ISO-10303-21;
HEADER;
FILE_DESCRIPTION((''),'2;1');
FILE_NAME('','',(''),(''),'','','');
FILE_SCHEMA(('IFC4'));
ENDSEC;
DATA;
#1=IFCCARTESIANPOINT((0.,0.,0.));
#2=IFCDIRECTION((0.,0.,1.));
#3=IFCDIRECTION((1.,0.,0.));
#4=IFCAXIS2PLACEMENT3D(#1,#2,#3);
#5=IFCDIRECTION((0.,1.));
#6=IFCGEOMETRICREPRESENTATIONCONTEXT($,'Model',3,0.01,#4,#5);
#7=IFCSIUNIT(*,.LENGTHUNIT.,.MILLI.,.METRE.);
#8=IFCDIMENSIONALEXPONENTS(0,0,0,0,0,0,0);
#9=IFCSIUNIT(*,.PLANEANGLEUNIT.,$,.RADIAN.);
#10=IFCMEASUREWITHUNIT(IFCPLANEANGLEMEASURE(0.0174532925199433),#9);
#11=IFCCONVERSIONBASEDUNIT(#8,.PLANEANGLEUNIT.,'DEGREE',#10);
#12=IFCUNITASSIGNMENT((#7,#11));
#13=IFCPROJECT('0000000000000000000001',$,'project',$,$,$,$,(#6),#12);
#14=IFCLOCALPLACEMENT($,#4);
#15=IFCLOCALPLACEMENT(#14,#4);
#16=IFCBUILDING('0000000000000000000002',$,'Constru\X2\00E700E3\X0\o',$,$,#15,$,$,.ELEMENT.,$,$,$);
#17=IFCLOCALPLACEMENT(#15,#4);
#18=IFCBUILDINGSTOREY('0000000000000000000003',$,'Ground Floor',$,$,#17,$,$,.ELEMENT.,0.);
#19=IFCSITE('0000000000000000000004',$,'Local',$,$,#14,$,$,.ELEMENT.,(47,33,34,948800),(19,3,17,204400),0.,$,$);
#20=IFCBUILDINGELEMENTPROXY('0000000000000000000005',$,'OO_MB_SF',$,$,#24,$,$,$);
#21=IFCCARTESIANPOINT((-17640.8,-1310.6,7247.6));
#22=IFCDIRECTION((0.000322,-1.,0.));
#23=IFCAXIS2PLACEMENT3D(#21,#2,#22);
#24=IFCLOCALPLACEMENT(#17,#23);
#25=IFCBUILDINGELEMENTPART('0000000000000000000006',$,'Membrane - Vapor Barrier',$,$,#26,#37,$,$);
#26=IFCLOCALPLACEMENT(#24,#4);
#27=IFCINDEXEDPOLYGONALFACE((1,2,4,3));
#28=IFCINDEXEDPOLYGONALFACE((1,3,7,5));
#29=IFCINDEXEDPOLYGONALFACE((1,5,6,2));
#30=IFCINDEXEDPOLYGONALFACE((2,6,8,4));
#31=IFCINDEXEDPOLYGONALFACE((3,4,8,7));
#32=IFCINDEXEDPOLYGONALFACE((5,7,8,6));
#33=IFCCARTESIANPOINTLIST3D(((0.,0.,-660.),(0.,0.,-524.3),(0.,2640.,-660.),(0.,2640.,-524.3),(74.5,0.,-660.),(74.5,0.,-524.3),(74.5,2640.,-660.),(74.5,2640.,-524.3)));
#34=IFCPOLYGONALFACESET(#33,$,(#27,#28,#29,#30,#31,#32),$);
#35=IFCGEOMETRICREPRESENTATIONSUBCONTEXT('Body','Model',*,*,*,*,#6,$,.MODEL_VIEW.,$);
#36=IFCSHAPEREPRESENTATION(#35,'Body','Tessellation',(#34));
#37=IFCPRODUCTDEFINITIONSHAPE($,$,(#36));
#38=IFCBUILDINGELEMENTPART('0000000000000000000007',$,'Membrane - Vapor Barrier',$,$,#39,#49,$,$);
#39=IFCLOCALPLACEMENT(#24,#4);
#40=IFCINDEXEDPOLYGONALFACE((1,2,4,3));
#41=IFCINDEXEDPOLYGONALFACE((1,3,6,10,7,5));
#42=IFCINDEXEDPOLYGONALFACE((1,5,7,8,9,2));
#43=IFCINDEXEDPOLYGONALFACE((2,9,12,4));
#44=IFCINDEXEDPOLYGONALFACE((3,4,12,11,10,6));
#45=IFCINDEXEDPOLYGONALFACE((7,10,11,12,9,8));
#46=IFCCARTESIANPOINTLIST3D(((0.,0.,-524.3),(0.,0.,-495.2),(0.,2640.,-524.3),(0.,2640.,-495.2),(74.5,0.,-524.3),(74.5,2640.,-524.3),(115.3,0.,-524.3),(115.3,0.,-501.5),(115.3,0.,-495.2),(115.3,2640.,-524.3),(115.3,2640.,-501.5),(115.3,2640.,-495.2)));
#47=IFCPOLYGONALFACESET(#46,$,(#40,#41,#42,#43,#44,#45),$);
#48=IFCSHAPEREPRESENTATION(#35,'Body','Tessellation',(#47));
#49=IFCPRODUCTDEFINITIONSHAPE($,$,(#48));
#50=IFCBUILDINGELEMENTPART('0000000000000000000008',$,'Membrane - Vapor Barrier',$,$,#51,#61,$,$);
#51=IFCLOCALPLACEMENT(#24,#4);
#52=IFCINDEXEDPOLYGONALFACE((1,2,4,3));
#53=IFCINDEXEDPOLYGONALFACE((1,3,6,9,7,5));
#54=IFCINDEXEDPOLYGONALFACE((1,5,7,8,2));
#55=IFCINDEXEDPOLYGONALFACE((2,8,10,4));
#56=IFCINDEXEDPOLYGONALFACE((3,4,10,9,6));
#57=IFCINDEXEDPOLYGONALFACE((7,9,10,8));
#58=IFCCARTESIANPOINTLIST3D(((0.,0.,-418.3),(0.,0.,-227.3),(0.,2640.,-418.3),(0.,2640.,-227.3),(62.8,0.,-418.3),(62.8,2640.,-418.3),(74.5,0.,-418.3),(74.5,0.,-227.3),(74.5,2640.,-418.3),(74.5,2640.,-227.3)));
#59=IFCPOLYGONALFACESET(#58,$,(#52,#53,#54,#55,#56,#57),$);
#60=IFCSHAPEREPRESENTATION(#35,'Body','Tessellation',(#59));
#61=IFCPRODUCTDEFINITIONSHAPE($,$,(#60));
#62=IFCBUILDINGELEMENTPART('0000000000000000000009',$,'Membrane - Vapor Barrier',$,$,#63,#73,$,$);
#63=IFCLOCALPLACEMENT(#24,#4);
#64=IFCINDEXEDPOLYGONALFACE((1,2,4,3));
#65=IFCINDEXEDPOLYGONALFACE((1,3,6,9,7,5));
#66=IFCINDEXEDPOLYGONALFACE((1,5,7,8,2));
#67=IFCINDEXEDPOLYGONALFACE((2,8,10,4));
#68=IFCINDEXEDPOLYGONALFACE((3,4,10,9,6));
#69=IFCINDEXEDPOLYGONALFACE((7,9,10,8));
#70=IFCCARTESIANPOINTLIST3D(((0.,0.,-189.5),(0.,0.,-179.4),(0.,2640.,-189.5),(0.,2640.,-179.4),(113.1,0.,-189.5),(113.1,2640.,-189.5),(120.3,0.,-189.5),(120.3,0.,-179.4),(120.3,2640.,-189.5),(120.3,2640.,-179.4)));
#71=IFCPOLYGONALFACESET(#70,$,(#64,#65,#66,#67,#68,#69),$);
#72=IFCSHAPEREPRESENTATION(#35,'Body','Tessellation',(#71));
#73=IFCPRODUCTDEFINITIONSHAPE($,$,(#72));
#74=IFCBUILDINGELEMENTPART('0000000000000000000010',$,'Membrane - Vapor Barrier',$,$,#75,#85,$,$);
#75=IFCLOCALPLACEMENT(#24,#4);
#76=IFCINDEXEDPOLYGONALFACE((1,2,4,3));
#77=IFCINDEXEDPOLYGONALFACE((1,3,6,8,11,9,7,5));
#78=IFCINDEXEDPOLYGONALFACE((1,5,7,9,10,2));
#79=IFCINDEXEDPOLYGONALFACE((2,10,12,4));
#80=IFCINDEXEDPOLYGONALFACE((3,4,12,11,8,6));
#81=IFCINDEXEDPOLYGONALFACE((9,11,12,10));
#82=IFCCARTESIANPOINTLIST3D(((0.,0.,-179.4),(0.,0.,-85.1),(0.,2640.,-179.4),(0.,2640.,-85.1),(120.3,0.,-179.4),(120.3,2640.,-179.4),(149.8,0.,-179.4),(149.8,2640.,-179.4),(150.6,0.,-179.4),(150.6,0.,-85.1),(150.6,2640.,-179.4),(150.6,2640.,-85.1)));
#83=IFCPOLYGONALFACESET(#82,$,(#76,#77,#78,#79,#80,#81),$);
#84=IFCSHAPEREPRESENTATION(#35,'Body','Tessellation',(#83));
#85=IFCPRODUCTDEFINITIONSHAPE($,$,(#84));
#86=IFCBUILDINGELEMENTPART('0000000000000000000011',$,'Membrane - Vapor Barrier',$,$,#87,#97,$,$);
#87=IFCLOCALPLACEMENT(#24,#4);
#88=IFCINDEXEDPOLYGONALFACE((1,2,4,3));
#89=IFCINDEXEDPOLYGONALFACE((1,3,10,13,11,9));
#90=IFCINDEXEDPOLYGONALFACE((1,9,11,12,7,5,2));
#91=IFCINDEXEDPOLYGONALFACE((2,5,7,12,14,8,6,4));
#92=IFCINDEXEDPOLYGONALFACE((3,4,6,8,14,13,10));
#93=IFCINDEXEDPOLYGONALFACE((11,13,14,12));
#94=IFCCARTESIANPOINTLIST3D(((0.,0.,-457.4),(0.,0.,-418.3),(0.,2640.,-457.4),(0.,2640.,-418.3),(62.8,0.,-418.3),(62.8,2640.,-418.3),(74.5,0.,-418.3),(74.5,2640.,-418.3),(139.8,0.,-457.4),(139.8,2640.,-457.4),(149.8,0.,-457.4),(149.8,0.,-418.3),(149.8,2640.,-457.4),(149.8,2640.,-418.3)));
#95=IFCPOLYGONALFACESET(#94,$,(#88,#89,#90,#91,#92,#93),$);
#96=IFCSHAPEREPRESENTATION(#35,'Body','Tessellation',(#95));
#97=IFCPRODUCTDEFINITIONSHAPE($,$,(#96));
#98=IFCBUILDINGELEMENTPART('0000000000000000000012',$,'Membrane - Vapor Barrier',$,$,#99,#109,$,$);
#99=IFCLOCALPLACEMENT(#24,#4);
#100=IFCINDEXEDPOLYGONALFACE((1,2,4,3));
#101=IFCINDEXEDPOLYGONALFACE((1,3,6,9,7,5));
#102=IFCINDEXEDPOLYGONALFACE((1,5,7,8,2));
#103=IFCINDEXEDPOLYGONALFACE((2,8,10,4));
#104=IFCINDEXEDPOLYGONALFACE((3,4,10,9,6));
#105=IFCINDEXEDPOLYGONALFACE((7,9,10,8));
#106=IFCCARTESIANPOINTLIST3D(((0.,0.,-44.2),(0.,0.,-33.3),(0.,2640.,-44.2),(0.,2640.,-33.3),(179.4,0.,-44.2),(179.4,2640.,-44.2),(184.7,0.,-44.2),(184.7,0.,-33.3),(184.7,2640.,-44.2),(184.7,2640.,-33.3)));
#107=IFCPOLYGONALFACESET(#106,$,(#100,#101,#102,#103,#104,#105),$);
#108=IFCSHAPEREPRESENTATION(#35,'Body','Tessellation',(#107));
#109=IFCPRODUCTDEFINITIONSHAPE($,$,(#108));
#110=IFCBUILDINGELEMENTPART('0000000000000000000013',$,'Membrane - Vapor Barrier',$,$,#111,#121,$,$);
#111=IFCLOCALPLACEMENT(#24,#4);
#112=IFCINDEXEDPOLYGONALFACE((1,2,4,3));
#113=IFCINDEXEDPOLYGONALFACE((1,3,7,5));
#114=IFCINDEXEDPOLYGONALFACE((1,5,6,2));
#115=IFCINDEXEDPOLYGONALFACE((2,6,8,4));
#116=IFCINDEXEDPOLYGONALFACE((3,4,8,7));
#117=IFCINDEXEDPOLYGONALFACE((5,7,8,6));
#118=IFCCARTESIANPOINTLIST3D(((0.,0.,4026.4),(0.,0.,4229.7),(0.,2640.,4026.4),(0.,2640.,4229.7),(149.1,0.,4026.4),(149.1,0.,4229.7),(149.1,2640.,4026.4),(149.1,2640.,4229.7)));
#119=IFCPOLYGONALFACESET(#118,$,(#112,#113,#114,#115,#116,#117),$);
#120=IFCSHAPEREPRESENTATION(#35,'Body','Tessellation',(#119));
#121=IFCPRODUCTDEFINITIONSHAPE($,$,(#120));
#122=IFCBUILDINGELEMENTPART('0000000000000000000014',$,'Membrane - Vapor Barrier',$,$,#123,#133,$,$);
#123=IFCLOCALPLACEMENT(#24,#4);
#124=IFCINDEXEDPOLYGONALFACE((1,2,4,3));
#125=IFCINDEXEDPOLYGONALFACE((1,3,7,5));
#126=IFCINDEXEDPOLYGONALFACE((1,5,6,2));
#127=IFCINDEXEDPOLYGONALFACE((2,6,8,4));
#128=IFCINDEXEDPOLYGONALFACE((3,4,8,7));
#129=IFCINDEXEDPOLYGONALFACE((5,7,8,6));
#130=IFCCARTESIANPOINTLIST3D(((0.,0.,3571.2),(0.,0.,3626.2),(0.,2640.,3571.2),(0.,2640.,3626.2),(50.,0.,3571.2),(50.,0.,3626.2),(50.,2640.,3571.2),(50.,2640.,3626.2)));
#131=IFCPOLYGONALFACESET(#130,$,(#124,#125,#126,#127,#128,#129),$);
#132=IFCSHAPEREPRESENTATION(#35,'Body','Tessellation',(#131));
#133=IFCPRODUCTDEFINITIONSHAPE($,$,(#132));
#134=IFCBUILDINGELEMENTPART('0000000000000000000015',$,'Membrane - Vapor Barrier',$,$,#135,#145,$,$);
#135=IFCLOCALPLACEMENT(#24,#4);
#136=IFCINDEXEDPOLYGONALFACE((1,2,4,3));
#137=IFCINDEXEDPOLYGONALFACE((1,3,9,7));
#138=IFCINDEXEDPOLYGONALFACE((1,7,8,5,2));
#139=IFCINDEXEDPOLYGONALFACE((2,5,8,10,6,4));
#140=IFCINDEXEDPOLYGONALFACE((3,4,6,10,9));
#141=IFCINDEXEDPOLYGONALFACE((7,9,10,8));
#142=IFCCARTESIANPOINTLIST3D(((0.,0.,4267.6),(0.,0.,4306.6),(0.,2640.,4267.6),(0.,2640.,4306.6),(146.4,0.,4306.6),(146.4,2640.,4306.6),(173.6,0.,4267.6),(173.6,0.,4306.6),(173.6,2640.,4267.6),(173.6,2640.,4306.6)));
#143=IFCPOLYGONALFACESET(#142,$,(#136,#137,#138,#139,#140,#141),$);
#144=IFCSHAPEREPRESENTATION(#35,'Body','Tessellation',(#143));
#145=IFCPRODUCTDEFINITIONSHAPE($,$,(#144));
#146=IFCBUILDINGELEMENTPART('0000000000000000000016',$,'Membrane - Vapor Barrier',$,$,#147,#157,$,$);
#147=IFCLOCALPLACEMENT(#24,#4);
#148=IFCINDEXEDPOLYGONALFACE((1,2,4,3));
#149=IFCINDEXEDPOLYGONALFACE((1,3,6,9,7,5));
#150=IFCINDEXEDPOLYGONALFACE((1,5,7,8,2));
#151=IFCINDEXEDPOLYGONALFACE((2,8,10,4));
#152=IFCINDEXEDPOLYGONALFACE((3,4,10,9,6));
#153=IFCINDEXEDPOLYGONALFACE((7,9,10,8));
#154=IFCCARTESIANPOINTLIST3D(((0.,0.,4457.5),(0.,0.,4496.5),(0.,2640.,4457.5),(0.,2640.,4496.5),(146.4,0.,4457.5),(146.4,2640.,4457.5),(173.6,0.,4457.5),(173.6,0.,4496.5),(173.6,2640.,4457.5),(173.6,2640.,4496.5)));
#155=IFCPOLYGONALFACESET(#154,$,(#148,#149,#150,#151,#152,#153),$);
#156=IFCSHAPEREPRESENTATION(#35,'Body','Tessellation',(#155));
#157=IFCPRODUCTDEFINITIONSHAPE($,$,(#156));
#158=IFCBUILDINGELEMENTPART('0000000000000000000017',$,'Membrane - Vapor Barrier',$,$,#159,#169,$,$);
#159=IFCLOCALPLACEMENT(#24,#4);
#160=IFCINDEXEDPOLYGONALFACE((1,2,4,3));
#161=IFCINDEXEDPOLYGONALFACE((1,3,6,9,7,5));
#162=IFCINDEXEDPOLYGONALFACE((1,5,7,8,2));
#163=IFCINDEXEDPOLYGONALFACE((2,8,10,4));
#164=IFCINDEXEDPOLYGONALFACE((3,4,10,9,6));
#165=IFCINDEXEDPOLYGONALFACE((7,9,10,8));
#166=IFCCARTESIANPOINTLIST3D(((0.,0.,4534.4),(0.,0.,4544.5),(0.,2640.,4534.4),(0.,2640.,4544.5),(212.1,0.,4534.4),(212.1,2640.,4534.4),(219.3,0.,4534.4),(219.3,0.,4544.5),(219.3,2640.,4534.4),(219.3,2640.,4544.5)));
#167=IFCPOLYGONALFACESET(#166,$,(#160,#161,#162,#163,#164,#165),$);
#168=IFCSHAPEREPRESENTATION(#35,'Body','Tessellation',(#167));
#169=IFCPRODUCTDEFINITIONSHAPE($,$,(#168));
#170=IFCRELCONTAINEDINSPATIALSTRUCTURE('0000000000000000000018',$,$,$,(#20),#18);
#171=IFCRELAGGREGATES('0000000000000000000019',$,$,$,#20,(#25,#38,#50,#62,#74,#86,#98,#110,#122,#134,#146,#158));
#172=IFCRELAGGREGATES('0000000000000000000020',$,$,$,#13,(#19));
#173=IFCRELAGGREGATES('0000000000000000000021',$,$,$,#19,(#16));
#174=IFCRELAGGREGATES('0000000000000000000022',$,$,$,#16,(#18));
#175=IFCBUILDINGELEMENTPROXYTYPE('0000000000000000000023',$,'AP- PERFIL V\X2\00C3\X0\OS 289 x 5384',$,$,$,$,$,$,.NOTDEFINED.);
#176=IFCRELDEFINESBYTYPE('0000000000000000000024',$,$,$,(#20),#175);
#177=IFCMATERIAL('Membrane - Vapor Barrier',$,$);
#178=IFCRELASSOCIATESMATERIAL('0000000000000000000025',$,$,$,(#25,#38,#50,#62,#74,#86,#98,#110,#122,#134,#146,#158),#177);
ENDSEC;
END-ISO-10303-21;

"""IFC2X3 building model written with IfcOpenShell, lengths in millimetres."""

from ifc_helpers import new_model, entity, si_unit, converted_unit, direction, frame, origin_with_axes, place, context, subcontext, project, spatial, polyline, outline, extrude, material, type_object, element, aggregate, save


model = new_model("IFC2X3")

# Units and contexts
model_context = context("Model", 3, precision=0.01, world=origin_with_axes(), true_north=direction((0.0, 1.0)))
body_context = subcontext(model_context, "Body", "Model", "MODEL_VIEW")
ifc_project = project(units=[si_unit("LENGTHUNIT", "METRE", prefix="MILLI"), converted_unit("PLANEANGLEUNIT", "DEGREE", entity("IfcPlaneAngleMeasure", 0.0174532925199433), si_unit("PLANEANGLEUNIT", "RADIAN"), dimensions=[0, 0, 0, 0, 0, 0, 0])], contexts=[model_context])

# Site, building, storey
site_placement = place(None, origin_with_axes())
site = spatial("IfcSite", under=ifc_project, at=site_placement, Name="Local", CompositionType="ELEMENT", RefLatitude=(47, 33, 34, 948800), RefLongitude=(19, 3, 17, 204400), RefElevation=0.0)
building_placement = place(site_placement, origin_with_axes())
building = spatial("IfcBuilding", under=site, at=building_placement, Name="Construção", CompositionType="ELEMENT")
storey_placement = place(building_placement, origin_with_axes())
storey = spatial("IfcBuildingStorey", under=building, at=storey_placement, Name="Ground Floor", CompositionType="ELEMENT", Elevation=0.0)

# Building element proxy, building element parts
building_element_proxy_type = type_object("IfcBuildingElementProxyType", Name="AP- PERFIL VÃOS 289 x 5384", PredefinedType="NOTDEFINED")
proxy_1_placement = place(storey_placement, frame((-17640.8, -1310.6, 7247.6), z_axis=(0.0, 0.0, 1.0), x_axis=(0.000322, -1.0, 0.0)))
proxy_1 = element("IfcBuildingElementProxy", 1, at=proxy_1_placement, inside=storey, type_object=building_element_proxy_type, Name="OO_MB_SF")
ifc_material = material(Name="Membrane - Vapor Barrier")
building_element_part_1_placement = place(proxy_1_placement, origin_with_axes())
building_element_part_1 = element("IfcBuildingElementPart", 2, at=building_element_part_1_placement, material=ifc_material, Name="Membrane - Vapor Barrier", context=body_context, shape_type="SweptSolid", body=[
    extrude(outline(polyline([(0.0, -660.0), (74.5, -660.0), (74.5, -524.3), (0.0, -524.3), (0.0, -660.0)])), frame((0.0, 2640.0, 0.0), z_axis=(0.0, -1.0, 0.0), x_axis=(1.0, 0.0, 0.0)), (0.0, 0.0, 1.0), 2640.0),
])
building_element_part_2_placement = place(proxy_1_placement, origin_with_axes())
building_element_part_2 = element("IfcBuildingElementPart", 3, at=building_element_part_2_placement, material=ifc_material, Name="Membrane - Vapor Barrier", context=body_context, shape_type="SweptSolid", body=[
    extrude(outline(polyline([(0.0, -524.3), (74.5, -524.3), (115.3, -524.3), (115.3, -501.5), (115.3, -495.2), (0.0, -495.2), (0.0, -524.3)])), frame((0.0, 2640.0, 0.0), z_axis=(0.0, -1.0, 0.0), x_axis=(1.0, 0.0, 0.0)), (0.0, 0.0, 1.0), 2640.0),
])
building_element_part_3_placement = place(proxy_1_placement, origin_with_axes())
building_element_part_3 = element("IfcBuildingElementPart", 4, at=building_element_part_3_placement, material=ifc_material, Name="Membrane - Vapor Barrier", context=body_context, shape_type="SweptSolid", body=[
    extrude(outline(polyline([(0.0, -227.3), (0.0, -418.3), (62.8, -418.3), (74.5, -418.3), (74.5, -227.3), (0.0, -227.3)])), frame((0.0, 2640.0, 0.0), z_axis=(0.0, -1.0, 0.0), x_axis=(1.0, 0.0, 0.0)), (0.0, 0.0, 1.0), 2640.0),
])
building_element_part_4_placement = place(proxy_1_placement, origin_with_axes())
building_element_part_4 = element("IfcBuildingElementPart", 5, at=building_element_part_4_placement, material=ifc_material, Name="Membrane - Vapor Barrier", context=body_context, shape_type="SweptSolid", body=[
    extrude(outline(polyline([(120.3, -179.4), (0.0, -179.4), (0.0, -189.5), (113.1, -189.5), (120.3, -189.5), (120.3, -179.4)])), frame((0.0, 2640.0, 0.0), z_axis=(0.0, -1.0, 0.0), x_axis=(1.0, 0.0, 0.0)), (0.0, 0.0, 1.0), 2640.0),
])
building_element_part_5_placement = place(proxy_1_placement, origin_with_axes())
building_element_part_5 = element("IfcBuildingElementPart", 6, at=building_element_part_5_placement, material=ifc_material, Name="Membrane - Vapor Barrier", context=body_context, shape_type="SweptSolid", body=[
    extrude(outline(polyline([(0.0, -85.1), (0.0, -179.4), (120.3, -179.4), (149.8, -179.4), (150.6, -179.4), (150.6, -85.1), (0.0, -85.1)])), frame((0.0, 2640.0, 0.0), z_axis=(0.0, -1.0, 0.0), x_axis=(1.0, 0.0, 0.0)), (0.0, 0.0, 1.0), 2640.0),
])
building_element_part_6_placement = place(proxy_1_placement, origin_with_axes())
building_element_part_6 = element("IfcBuildingElementPart", 7, at=building_element_part_6_placement, material=ifc_material, Name="Membrane - Vapor Barrier", context=body_context, shape_type="SweptSolid", body=[
    extrude(outline(polyline([(62.8, -418.3), (0.0, -418.3), (0.0, -457.4), (139.8, -457.4), (149.8, -457.4), (149.8, -418.3), (74.5, -418.3), (62.8, -418.3)])), frame((0.0, 2640.0, 0.0), z_axis=(0.0, -1.0, 0.0), x_axis=(1.0, 0.0, 0.0)), (0.0, 0.0, 1.0), 2640.0),
])
building_element_part_7_placement = place(proxy_1_placement, origin_with_axes())
building_element_part_7 = element("IfcBuildingElementPart", 8, at=building_element_part_7_placement, material=ifc_material, Name="Membrane - Vapor Barrier", context=body_context, shape_type="SweptSolid", body=[
    extrude(outline(polyline([(184.7, -33.3), (0.0, -33.3), (0.0, -44.2), (179.4, -44.2), (184.7, -44.2), (184.7, -33.3)])), frame((0.0, 2640.0, 0.0), z_axis=(0.0, -1.0, 0.0), x_axis=(1.0, 0.0, 0.0)), (0.0, 0.0, 1.0), 2640.0),
])
building_element_part_8_placement = place(proxy_1_placement, origin_with_axes())
building_element_part_8 = element("IfcBuildingElementPart", 9, at=building_element_part_8_placement, material=ifc_material, Name="Membrane - Vapor Barrier", context=body_context, shape_type="SweptSolid", body=[
    extrude(outline(polyline([(149.1, 4229.7), (0.0, 4229.7), (0.0, 4026.4), (149.1, 4026.4), (149.1, 4229.7)])), frame((0.0, 2640.0, 0.0), z_axis=(0.0, -1.0, 0.0), x_axis=(1.0, 0.0, 0.0)), (0.0, 0.0, 1.0), 2640.0),
])
building_element_part_9_placement = place(proxy_1_placement, origin_with_axes())
building_element_part_9 = element("IfcBuildingElementPart", 10, at=building_element_part_9_placement, material=ifc_material, Name="Membrane - Vapor Barrier", context=body_context, shape_type="SweptSolid", body=[
    extrude(outline(polyline([(0.0, 3571.2), (50.0, 3571.2), (50.0, 3626.2), (0.0, 3626.2), (0.0, 3571.2)])), frame((0.0, 2640.0, 0.0), z_axis=(0.0, -1.0, 0.0), x_axis=(1.0, 0.0, 0.0)), (0.0, 0.0, 1.0), 2640.0),
])
building_element_part_10_placement = place(proxy_1_placement, origin_with_axes())
building_element_part_10 = element("IfcBuildingElementPart", 11, at=building_element_part_10_placement, material=ifc_material, Name="Membrane - Vapor Barrier", context=body_context, shape_type="SweptSolid", body=[
    extrude(outline(polyline([(0.0, 4306.6), (0.0, 4267.6), (173.6, 4267.6), (173.6, 4306.6), (146.4, 4306.6), (0.0, 4306.6)])), frame((0.0, 2640.0, 0.0), z_axis=(0.0, -1.0, 0.0), x_axis=(1.0, 0.0, 0.0)), (0.0, 0.0, 1.0), 2640.0),
])
building_element_part_11_placement = place(proxy_1_placement, origin_with_axes())
building_element_part_11 = element("IfcBuildingElementPart", 12, at=building_element_part_11_placement, material=ifc_material, Name="Membrane - Vapor Barrier", context=body_context, shape_type="SweptSolid", body=[
    extrude(outline(polyline([(173.6, 4496.5), (0.0, 4496.5), (0.0, 4457.5), (146.4, 4457.5), (173.6, 4457.5), (173.6, 4496.5)])), frame((0.0, 2640.0, 0.0), z_axis=(0.0, -1.0, 0.0), x_axis=(1.0, 0.0, 0.0)), (0.0, 0.0, 1.0), 2640.0),
])
building_element_part_12_placement = place(proxy_1_placement, origin_with_axes())
building_element_part_12 = element("IfcBuildingElementPart", 13, at=building_element_part_12_placement, material=ifc_material, Name="Membrane - Vapor Barrier", context=body_context, shape_type="SweptSolid", body=[
    extrude(outline(polyline([(0.0, 4534.4), (212.1, 4534.4), (219.3, 4534.4), (219.3, 4544.5), (0.0, 4544.5), (0.0, 4534.4)])), frame((0.0, 2640.0, 0.0), z_axis=(0.0, -1.0, 0.0), x_axis=(1.0, 0.0, 0.0)), (0.0, 0.0, 1.0), 2640.0),
])
aggregate(proxy_1, [building_element_part_1, building_element_part_2, building_element_part_3, building_element_part_4, building_element_part_5, building_element_part_6, building_element_part_7, building_element_part_8, building_element_part_9, building_element_part_10, building_element_part_11, building_element_part_12])

save(model, "model.ifc")
